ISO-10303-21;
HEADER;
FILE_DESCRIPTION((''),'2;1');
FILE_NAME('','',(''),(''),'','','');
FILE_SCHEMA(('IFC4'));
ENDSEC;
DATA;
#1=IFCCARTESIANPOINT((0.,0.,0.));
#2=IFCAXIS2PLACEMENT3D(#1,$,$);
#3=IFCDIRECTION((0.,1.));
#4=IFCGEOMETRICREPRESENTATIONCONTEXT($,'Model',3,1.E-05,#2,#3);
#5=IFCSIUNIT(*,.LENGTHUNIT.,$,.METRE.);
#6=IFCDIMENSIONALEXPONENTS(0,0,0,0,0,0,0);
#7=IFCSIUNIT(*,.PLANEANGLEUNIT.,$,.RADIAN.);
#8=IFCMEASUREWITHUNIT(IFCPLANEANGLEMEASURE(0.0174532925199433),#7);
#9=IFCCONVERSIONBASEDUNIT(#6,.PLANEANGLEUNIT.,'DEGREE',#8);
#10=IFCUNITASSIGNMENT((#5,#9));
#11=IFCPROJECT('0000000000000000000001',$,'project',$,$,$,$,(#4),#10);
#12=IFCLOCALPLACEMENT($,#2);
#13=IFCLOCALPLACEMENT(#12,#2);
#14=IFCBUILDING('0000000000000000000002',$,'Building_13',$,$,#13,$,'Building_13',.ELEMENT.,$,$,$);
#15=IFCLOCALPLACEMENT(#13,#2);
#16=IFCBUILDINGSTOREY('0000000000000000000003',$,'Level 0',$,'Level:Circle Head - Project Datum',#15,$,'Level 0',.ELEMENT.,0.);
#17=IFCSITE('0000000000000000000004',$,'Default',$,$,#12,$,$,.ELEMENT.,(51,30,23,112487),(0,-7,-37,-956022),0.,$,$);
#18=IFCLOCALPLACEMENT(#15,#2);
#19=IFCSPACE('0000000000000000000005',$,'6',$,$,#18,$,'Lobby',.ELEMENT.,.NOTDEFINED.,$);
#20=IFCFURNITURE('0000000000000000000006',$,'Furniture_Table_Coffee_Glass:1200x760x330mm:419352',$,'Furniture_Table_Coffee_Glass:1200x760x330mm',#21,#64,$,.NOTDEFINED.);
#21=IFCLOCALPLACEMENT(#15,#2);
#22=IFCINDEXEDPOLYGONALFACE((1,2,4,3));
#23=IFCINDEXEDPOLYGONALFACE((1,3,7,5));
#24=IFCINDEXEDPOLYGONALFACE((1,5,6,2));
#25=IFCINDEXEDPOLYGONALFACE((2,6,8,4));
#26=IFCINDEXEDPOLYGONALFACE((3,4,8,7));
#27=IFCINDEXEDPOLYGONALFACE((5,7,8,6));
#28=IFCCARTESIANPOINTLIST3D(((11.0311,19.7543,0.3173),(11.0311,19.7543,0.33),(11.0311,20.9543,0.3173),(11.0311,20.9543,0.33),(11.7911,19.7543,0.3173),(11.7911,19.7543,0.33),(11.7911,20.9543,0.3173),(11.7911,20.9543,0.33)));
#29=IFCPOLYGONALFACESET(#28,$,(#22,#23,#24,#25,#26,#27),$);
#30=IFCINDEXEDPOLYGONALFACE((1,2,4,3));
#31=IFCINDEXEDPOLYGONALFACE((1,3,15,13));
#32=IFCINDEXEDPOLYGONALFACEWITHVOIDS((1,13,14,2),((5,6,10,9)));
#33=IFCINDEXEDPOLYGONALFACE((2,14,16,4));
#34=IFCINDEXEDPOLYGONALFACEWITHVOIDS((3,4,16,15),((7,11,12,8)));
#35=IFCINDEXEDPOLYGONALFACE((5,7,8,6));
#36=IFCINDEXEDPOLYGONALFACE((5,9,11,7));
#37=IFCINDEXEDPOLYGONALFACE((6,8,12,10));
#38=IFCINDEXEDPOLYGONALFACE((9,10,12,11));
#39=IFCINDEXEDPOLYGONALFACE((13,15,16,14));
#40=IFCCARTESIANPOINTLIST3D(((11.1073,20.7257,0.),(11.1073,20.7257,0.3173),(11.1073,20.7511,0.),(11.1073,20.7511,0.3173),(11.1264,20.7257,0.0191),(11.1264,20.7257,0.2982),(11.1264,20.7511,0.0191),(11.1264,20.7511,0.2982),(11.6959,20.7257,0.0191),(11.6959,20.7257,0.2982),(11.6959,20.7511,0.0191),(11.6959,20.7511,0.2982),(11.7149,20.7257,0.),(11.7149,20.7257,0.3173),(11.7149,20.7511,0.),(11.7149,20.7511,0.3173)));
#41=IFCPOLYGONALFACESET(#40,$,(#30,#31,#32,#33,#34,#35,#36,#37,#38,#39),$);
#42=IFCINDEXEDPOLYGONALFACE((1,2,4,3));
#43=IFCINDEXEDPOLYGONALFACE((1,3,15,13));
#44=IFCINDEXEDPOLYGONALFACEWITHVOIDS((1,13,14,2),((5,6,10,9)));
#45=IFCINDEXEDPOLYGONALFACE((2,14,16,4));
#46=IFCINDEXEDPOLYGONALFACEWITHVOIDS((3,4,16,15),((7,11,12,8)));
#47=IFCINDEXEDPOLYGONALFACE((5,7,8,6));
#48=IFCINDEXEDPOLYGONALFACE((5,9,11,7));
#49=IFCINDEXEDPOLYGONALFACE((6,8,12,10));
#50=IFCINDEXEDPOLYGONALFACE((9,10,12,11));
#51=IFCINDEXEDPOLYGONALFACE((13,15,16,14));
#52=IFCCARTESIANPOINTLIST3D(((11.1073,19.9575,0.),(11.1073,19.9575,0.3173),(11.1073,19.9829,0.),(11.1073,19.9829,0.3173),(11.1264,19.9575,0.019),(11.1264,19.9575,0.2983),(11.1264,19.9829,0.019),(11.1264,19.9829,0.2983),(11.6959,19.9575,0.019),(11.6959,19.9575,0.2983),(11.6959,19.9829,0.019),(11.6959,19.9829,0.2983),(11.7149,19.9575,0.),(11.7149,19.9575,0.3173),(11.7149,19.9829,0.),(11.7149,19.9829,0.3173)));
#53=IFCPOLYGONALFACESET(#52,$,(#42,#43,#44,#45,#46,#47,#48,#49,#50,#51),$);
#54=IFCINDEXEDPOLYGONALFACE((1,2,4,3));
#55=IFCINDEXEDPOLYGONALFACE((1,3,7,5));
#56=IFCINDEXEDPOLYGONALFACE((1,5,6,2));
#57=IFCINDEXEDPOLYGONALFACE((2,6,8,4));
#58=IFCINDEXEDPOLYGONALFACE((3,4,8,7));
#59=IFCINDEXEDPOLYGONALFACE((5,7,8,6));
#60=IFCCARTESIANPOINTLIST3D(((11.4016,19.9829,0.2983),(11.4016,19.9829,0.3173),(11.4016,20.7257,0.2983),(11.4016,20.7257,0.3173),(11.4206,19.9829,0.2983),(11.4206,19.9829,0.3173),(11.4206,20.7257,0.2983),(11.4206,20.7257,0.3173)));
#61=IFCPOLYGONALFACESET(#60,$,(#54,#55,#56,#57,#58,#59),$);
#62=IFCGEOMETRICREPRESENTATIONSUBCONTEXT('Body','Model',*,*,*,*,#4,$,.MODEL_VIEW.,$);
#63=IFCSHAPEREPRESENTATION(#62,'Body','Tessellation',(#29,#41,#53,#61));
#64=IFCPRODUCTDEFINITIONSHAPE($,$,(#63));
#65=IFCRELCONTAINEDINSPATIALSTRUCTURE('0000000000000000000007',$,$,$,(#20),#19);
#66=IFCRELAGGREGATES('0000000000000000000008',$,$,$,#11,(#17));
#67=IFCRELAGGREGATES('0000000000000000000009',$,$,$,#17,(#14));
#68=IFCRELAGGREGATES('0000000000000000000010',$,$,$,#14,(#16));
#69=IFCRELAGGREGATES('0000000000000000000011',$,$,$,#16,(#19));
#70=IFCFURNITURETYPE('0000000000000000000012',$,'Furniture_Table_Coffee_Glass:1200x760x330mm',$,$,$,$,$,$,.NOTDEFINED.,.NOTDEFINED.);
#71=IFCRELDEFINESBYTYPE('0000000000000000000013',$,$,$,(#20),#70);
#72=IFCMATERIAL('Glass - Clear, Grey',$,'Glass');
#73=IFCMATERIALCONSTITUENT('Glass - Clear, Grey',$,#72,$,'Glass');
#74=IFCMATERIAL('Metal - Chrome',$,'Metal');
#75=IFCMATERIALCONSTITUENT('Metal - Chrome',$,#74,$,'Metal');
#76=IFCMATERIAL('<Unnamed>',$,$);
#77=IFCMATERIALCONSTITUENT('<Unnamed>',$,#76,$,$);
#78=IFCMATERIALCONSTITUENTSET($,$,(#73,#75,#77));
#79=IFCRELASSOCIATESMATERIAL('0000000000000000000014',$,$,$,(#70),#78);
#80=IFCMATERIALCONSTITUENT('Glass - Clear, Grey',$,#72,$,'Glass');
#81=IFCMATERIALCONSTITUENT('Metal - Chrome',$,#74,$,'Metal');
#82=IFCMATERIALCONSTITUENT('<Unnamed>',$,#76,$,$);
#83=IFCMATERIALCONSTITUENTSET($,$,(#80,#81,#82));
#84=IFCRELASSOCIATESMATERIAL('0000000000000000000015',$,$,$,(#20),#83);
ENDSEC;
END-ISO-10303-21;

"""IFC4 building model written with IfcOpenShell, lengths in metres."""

from ifc_helpers import new_model, entity, si_unit, converted_unit, direction, frame, origin, place, context, subcontext, project, spatial, indexed_curve, outline, extrude, source, transform, mapped, material, constituent, constituent_set, type_object, type_shapes, element, save


model = new_model("IFC4")

# Units and contexts
model_context = context("Model", 3, precision=1e-05, world=origin(), true_north=direction((0.0, 1.0)))
body_context = subcontext(model_context, "Body", "Model", "MODEL_VIEW")
ifc_project = project(units=[si_unit("LENGTHUNIT", "METRE"), converted_unit("PLANEANGLEUNIT", "DEGREE", entity("IfcPlaneAngleMeasure", 0.0174532925199433), si_unit("PLANEANGLEUNIT", "RADIAN"), dimensions=[0, 0, 0, 0, 0, 0, 0])], contexts=[model_context])

# Site, building, storey
site_placement = place(None, origin())
site = spatial("IfcSite", under=ifc_project, at=site_placement, Name="Default", CompositionType="ELEMENT", RefLatitude=(51, 30, 23, 112487), RefLongitude=(0, -7, -37, -956022), RefElevation=0.0)
building_placement = place(site_placement, origin())
building = spatial("IfcBuilding", under=site, at=building_placement, Name="Building_13", LongName="Building_13", CompositionType="ELEMENT")
storey_placement = place(building_placement, origin())
storey = spatial("IfcBuildingStorey", under=building, at=storey_placement, Name="Level 0", ObjectType="Level:Circle Head - Project Datum", LongName="Level 0", CompositionType="ELEMENT", Elevation=0.0)

# Shared definitions
ifc_material_1 = material(Name="Glass - Clear, Grey", Category="Glass")
ifc_material_2 = material(Name="Metal - Chrome", Category="Metal")
ifc_material_3 = material(Name="<Unnamed>")

# Shared definitions
space_1_placement = place(storey_placement, origin())
space_1 = spatial("IfcSpace", under=storey, at=space_1_placement, Name="6", LongName="Lobby", CompositionType="ELEMENT", PredefinedType="NOTDEFINED")

# Furniture
ifc_constituent_1 = constituent(ifc_material_1, Name="Glass - Clear, Grey", Category="Glass")
ifc_constituent_2 = constituent(ifc_material_2, Name="Metal - Chrome", Category="Metal")
ifc_constituent_3 = constituent(ifc_material_3, Name="<Unnamed>")
ifc_constituent_set_1 = constituent_set(constituents=[ifc_constituent_1, ifc_constituent_2, ifc_constituent_3])
furniture_type_1 = type_object("IfcFurnitureType", Name="Furniture_Table_Coffee_Glass:1200x760x330mm", AssemblyPlace="NOTDEFINED", PredefinedType="NOTDEFINED", material=ifc_constituent_set_1)
shared_shape_1 = source(origin(), body_context, "Body", "SweptSolid", [
    extrude(outline(indexed_curve([(-0.38, -0.6), (0.38, -0.6), (0.38, 0.6), (-0.38, 0.6), (-0.38, -0.6)], self_intersect=False)), frame((0.6037, -0.3686, 0.3173), z_axis=(0.0, 0.0, 1.0), x_axis=(0.0, 1.0, 0.0)), (0.0, 0.0, 1.0), 0.0127),
    extrude(outline(indexed_curve([(-0.3038, -0.1587), (0.3038, -0.1587), (0.3038, 0.1587), (-0.3038, 0.1587), (-0.3038, -0.1587)], self_intersect=False), holes=[indexed_curve([(-0.2848, -0.1396), (-0.2848, 0.1396), (0.2848, 0.1396), (0.2848, -0.1396), (-0.2848, -0.1396)], self_intersect=False)]), frame((0.2069, -0.3686, 0.1587), z_axis=(1.0, 0.0, 0.0), x_axis=(0.0, -1.0, 0.0)), (0.0, 0.0, 1.0), 0.0254),
    extrude(outline(indexed_curve([(-0.3038, -0.1586), (0.3038, -0.1586), (0.3038, 0.1586), (-0.3038, 0.1586), (-0.3038, -0.1586)], self_intersect=False), holes=[indexed_curve([(-0.2848, -0.1396), (-0.2848, 0.1396), (0.2848, 0.1396), (0.2848, -0.1396), (-0.2848, -0.1396)], self_intersect=False)]), frame((0.9751, -0.3686, 0.1586), z_axis=(1.0, 0.0, 0.0), x_axis=(0.0, -1.0, 0.0)), (0.0, 0.0, 1.0), 0.0254),
    extrude(outline(indexed_curve([(-0.0095, -0.3714), (0.0095, -0.3714), (0.0095, 0.3714), (-0.0095, 0.3714), (-0.0095, -0.3714)], self_intersect=False)), frame((0.6037, -0.3686, 0.2983), z_axis=(0.0, 0.0, 1.0), x_axis=(0.0, 1.0, 0.0)), (0.0, 0.0, 1.0), 0.0191),
])
type_shapes(furniture_type_1, [shared_shape_1])
ifc_constituent_4 = constituent(ifc_material_1, Name="Glass - Clear, Grey", Category="Glass")
ifc_constituent_5 = constituent(ifc_material_2, Name="Metal - Chrome", Category="Metal")
ifc_constituent_6 = constituent(ifc_material_3, Name="<Unnamed>")
ifc_constituent_set_2 = constituent_set(constituents=[ifc_constituent_4, ifc_constituent_5, ifc_constituent_6])
furniture_1_placement = place(space_1_placement, frame((11.7797, 20.9581, 0.0), z_axis=(0.0, 0.0, 1.0), x_axis=(0.0, -1.0, 0.0)))
element("IfcFurniture", 1, at=furniture_1_placement, inside=space_1, type_object=furniture_type_1, material=ifc_constituent_set_2, Name="Furniture_Table_Coffee_Glass:1200x760x330mm:419352", ObjectType="Furniture_Table_Coffee_Glass:1200x760x330mm", PredefinedType="NOTDEFINED", context=body_context, shape_type="MappedRepresentation", body=[
    mapped(shared_shape_1, transform((0.0, 0.0, 0.0), scale=1.0)),
])

save(model, "model.ifc")
